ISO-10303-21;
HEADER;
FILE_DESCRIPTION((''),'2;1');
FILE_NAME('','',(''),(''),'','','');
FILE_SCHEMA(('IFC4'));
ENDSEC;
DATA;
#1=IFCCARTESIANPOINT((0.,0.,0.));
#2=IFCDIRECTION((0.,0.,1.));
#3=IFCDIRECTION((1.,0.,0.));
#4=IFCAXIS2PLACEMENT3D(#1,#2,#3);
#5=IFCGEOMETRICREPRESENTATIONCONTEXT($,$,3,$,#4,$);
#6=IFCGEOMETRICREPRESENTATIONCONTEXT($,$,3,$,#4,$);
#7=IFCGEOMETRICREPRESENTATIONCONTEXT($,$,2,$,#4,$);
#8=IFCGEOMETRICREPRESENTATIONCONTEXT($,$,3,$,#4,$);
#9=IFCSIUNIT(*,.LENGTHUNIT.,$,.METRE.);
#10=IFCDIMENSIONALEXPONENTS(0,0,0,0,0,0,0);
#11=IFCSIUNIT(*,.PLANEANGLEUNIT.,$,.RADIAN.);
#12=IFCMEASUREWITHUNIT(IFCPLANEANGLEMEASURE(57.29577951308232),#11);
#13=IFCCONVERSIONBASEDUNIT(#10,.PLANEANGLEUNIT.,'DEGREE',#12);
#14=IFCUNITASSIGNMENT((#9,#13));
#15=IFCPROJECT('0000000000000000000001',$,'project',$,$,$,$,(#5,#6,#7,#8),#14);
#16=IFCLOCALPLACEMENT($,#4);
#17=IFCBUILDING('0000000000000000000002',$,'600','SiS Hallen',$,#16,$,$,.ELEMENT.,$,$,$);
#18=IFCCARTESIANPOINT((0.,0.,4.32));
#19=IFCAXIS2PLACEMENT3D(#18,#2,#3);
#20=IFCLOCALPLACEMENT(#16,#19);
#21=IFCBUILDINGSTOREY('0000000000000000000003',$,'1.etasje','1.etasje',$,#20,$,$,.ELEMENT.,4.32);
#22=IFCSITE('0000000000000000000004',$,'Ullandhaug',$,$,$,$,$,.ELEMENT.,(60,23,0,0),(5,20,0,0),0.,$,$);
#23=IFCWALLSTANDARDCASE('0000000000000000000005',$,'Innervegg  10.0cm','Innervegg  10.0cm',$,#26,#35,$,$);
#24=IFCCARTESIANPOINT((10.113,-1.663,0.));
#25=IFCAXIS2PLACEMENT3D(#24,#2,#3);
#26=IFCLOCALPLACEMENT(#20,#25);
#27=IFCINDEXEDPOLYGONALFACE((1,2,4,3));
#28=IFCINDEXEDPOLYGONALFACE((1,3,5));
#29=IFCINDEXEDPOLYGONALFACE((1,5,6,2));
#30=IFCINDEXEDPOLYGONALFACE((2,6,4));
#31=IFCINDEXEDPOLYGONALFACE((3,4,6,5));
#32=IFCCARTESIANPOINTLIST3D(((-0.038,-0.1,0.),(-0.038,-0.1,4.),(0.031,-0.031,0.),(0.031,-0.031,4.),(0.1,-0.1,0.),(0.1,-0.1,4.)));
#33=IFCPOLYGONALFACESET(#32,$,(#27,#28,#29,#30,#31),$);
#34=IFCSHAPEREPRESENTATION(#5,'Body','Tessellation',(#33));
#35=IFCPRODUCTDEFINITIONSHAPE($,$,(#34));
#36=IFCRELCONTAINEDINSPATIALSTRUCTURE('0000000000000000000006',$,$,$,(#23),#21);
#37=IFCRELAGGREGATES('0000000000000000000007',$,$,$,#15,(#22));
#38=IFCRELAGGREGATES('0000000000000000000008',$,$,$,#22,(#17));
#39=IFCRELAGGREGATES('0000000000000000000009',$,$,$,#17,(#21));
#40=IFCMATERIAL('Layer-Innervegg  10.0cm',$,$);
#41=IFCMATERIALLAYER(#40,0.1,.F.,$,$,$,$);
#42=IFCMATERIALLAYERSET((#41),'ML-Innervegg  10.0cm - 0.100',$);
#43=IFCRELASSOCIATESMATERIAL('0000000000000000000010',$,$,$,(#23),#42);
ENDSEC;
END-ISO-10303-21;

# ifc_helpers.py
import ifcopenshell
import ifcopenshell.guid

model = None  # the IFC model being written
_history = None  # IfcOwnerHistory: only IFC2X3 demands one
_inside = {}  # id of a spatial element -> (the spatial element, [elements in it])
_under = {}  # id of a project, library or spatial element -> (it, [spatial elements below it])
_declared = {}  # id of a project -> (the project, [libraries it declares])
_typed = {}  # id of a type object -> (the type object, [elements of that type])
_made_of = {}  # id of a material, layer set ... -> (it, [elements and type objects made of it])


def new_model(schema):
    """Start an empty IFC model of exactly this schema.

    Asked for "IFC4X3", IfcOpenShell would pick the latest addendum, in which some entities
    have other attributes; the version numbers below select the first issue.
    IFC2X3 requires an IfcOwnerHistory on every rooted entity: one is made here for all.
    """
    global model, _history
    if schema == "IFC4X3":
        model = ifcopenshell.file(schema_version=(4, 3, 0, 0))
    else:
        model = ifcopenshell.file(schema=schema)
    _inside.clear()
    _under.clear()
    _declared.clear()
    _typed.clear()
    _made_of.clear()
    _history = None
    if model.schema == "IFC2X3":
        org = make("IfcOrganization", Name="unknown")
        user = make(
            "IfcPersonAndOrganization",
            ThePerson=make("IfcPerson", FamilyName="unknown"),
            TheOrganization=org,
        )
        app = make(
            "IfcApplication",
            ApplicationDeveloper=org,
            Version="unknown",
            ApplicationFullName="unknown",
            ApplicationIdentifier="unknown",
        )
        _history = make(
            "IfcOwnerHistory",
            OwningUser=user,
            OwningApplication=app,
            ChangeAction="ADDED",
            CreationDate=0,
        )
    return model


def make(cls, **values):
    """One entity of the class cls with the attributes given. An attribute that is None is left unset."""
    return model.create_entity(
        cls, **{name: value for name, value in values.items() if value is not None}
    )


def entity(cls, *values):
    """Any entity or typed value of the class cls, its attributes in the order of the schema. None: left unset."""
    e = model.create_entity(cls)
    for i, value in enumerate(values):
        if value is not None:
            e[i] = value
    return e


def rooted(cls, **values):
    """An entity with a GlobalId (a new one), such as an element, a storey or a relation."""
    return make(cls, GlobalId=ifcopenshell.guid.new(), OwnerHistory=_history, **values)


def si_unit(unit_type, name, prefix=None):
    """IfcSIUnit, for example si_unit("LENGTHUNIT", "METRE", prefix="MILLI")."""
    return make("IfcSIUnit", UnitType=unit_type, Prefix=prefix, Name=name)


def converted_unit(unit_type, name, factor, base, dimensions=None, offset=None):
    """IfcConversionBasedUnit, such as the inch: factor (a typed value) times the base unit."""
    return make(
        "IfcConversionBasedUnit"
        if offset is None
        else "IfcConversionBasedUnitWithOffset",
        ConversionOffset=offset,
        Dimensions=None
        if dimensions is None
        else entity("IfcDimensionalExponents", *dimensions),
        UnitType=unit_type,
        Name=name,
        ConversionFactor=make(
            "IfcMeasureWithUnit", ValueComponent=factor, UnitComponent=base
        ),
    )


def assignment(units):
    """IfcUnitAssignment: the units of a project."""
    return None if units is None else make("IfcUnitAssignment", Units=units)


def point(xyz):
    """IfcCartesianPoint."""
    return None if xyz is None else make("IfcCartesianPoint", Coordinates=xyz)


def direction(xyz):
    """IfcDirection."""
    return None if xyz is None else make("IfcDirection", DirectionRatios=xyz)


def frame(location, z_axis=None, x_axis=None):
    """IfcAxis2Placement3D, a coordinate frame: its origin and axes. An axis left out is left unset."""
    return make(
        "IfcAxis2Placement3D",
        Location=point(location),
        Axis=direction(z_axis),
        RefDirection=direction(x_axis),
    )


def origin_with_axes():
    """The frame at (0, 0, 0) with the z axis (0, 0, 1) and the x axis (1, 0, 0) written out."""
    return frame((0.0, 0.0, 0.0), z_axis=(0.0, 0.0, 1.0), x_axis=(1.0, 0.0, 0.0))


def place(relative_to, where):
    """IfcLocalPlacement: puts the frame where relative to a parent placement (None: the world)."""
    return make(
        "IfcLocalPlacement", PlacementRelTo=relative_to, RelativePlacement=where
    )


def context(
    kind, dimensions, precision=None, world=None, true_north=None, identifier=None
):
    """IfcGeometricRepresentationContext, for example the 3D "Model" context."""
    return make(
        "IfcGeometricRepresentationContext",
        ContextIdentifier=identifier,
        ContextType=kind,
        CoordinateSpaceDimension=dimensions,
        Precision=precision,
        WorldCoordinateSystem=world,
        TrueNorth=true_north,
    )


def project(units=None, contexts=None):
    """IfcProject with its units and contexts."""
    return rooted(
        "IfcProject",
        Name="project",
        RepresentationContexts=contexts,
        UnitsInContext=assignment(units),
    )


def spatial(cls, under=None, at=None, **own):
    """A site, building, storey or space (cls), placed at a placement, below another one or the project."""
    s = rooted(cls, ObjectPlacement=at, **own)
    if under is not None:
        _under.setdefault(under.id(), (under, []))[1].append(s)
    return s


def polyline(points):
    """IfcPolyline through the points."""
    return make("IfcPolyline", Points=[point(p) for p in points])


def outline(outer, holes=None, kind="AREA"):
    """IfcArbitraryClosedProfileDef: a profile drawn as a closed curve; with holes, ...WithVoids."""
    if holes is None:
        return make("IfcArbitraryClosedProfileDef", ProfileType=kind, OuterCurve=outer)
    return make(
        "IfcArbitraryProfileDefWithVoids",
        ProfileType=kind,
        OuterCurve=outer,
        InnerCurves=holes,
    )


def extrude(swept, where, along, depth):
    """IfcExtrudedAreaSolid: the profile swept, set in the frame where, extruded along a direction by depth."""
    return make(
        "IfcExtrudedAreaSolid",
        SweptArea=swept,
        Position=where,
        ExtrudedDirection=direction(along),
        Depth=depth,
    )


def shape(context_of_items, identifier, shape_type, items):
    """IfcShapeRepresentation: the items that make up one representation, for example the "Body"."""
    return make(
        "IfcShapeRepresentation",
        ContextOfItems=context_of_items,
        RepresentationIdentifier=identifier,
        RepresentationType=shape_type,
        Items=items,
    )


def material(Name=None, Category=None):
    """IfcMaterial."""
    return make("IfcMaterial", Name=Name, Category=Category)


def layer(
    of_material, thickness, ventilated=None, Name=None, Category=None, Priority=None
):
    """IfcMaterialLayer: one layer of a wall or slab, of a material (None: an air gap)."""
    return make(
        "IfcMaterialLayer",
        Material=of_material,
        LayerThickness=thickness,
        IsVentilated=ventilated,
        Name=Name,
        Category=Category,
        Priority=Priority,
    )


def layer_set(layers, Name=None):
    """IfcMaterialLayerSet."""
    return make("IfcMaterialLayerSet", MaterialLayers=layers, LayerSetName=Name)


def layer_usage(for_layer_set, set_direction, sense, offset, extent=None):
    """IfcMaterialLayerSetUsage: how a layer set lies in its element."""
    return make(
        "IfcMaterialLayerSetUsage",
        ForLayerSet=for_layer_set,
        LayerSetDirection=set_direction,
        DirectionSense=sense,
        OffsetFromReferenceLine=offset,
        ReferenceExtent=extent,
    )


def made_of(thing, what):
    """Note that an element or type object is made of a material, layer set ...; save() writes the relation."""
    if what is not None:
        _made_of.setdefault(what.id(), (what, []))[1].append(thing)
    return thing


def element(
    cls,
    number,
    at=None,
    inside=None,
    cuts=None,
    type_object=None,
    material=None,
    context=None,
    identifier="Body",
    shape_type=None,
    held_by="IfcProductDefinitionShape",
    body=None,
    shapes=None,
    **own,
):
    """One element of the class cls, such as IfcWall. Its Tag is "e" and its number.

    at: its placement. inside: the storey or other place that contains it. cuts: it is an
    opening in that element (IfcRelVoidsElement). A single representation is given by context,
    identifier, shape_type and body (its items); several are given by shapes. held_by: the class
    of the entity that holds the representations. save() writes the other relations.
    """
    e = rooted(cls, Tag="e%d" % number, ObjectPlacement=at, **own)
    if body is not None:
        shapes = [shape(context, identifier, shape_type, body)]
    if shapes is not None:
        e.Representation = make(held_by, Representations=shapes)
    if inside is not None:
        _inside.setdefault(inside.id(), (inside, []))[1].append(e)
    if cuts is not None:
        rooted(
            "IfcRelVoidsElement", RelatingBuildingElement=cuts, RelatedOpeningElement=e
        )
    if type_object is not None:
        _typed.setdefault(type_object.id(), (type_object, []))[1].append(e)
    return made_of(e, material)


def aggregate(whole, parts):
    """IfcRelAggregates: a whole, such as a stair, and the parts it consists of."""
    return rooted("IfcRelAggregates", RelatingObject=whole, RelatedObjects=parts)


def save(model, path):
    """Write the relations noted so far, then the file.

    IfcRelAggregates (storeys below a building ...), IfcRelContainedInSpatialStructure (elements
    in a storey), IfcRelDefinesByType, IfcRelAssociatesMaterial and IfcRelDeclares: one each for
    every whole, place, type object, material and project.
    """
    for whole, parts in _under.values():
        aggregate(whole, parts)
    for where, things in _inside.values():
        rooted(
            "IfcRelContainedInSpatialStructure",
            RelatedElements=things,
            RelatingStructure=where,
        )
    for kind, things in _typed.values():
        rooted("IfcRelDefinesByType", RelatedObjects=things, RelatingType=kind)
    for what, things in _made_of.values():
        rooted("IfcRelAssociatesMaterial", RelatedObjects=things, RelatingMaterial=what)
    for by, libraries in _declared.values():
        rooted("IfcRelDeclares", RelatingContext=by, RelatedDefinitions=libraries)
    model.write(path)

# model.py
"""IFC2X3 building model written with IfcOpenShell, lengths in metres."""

from ifc_helpers import new_model, entity, si_unit, converted_unit, frame, origin_with_axes, place, context, project, spatial, polyline, outline, extrude, material, layer, layer_set, layer_usage, element, save


model = new_model("IFC2X3")

# Units and contexts
context_of_model_1 = context(None, 3, world=origin_with_axes())
context_of_model_2 = context(None, 3, world=origin_with_axes())
context_of_model_3 = context(None, 2, world=origin_with_axes())
context_of_model_4 = context(None, 3, world=origin_with_axes())
ifc_project = project(units=[si_unit("LENGTHUNIT", "METRE"), converted_unit("PLANEANGLEUNIT", "DEGREE", entity("IfcPlaneAngleMeasure", 57.29577951308232), si_unit("PLANEANGLEUNIT", "RADIAN"), dimensions=[0, 0, 0, 0, 0, 0, 0])], contexts=[context_of_model_1, context_of_model_2, context_of_model_3, context_of_model_4])

# Site, building, storey
site = spatial("IfcSite", under=ifc_project, Name="Ullandhaug", CompositionType="ELEMENT", RefLatitude=(60, 23, 0, 0), RefLongitude=(5, 20, 0, 0), RefElevation=0.0)
building_placement = place(None, origin_with_axes())
building = spatial("IfcBuilding", under=site, at=building_placement, Name="600", Description="SiS Hallen", CompositionType="ELEMENT")
storey_placement = place(building_placement, frame((0.0, 0.0, 4.32), z_axis=(0.0, 0.0, 1.0), x_axis=(1.0, 0.0, 0.0)))
storey = spatial("IfcBuildingStorey", under=building, at=storey_placement, Name="1.etasje", Description="1.etasje", CompositionType="ELEMENT", Elevation=4.32)

# Shared definitions
ifc_material_1 = material(Name="Layer-Innervegg  10.0cm")
ifc_layer_1 = layer(ifc_material_1, 0.1, ventilated=False)
ifc_layer_set_1 = layer_set([ifc_layer_1], Name="ML-Innervegg  10.0cm - 0.100")
ifc_layer_usage_1 = layer_usage(ifc_layer_set_1, "AXIS2", "POSITIVE", 0.0)

# Wall
wall_1_placement = place(storey_placement, frame((10.113, -1.663, 0.0), z_axis=(0.0, 0.0, 1.0), x_axis=(1.0, 0.0, 0.0)))
element("IfcWallStandardCase", 1, at=wall_1_placement, inside=storey, material=ifc_layer_usage_1, Name="Innervegg  10.0cm", Description="Innervegg  10.0cm", context=context_of_model_1, shape_type="SweptSolid", body=[
    extrude(outline(polyline([(0.0, 0.0), (0.062, 0.0), (-0.038, 0.1), (0.1, 0.1), (0.0, 0.0)])), frame((0.0, 0.0, 0.0), z_axis=(0.0, 0.0, -1.0), x_axis=(1.0, 0.0, 0.0)), (0.0, 0.0, -1.0), 4.0),
])

save(model, "model.ifc")
